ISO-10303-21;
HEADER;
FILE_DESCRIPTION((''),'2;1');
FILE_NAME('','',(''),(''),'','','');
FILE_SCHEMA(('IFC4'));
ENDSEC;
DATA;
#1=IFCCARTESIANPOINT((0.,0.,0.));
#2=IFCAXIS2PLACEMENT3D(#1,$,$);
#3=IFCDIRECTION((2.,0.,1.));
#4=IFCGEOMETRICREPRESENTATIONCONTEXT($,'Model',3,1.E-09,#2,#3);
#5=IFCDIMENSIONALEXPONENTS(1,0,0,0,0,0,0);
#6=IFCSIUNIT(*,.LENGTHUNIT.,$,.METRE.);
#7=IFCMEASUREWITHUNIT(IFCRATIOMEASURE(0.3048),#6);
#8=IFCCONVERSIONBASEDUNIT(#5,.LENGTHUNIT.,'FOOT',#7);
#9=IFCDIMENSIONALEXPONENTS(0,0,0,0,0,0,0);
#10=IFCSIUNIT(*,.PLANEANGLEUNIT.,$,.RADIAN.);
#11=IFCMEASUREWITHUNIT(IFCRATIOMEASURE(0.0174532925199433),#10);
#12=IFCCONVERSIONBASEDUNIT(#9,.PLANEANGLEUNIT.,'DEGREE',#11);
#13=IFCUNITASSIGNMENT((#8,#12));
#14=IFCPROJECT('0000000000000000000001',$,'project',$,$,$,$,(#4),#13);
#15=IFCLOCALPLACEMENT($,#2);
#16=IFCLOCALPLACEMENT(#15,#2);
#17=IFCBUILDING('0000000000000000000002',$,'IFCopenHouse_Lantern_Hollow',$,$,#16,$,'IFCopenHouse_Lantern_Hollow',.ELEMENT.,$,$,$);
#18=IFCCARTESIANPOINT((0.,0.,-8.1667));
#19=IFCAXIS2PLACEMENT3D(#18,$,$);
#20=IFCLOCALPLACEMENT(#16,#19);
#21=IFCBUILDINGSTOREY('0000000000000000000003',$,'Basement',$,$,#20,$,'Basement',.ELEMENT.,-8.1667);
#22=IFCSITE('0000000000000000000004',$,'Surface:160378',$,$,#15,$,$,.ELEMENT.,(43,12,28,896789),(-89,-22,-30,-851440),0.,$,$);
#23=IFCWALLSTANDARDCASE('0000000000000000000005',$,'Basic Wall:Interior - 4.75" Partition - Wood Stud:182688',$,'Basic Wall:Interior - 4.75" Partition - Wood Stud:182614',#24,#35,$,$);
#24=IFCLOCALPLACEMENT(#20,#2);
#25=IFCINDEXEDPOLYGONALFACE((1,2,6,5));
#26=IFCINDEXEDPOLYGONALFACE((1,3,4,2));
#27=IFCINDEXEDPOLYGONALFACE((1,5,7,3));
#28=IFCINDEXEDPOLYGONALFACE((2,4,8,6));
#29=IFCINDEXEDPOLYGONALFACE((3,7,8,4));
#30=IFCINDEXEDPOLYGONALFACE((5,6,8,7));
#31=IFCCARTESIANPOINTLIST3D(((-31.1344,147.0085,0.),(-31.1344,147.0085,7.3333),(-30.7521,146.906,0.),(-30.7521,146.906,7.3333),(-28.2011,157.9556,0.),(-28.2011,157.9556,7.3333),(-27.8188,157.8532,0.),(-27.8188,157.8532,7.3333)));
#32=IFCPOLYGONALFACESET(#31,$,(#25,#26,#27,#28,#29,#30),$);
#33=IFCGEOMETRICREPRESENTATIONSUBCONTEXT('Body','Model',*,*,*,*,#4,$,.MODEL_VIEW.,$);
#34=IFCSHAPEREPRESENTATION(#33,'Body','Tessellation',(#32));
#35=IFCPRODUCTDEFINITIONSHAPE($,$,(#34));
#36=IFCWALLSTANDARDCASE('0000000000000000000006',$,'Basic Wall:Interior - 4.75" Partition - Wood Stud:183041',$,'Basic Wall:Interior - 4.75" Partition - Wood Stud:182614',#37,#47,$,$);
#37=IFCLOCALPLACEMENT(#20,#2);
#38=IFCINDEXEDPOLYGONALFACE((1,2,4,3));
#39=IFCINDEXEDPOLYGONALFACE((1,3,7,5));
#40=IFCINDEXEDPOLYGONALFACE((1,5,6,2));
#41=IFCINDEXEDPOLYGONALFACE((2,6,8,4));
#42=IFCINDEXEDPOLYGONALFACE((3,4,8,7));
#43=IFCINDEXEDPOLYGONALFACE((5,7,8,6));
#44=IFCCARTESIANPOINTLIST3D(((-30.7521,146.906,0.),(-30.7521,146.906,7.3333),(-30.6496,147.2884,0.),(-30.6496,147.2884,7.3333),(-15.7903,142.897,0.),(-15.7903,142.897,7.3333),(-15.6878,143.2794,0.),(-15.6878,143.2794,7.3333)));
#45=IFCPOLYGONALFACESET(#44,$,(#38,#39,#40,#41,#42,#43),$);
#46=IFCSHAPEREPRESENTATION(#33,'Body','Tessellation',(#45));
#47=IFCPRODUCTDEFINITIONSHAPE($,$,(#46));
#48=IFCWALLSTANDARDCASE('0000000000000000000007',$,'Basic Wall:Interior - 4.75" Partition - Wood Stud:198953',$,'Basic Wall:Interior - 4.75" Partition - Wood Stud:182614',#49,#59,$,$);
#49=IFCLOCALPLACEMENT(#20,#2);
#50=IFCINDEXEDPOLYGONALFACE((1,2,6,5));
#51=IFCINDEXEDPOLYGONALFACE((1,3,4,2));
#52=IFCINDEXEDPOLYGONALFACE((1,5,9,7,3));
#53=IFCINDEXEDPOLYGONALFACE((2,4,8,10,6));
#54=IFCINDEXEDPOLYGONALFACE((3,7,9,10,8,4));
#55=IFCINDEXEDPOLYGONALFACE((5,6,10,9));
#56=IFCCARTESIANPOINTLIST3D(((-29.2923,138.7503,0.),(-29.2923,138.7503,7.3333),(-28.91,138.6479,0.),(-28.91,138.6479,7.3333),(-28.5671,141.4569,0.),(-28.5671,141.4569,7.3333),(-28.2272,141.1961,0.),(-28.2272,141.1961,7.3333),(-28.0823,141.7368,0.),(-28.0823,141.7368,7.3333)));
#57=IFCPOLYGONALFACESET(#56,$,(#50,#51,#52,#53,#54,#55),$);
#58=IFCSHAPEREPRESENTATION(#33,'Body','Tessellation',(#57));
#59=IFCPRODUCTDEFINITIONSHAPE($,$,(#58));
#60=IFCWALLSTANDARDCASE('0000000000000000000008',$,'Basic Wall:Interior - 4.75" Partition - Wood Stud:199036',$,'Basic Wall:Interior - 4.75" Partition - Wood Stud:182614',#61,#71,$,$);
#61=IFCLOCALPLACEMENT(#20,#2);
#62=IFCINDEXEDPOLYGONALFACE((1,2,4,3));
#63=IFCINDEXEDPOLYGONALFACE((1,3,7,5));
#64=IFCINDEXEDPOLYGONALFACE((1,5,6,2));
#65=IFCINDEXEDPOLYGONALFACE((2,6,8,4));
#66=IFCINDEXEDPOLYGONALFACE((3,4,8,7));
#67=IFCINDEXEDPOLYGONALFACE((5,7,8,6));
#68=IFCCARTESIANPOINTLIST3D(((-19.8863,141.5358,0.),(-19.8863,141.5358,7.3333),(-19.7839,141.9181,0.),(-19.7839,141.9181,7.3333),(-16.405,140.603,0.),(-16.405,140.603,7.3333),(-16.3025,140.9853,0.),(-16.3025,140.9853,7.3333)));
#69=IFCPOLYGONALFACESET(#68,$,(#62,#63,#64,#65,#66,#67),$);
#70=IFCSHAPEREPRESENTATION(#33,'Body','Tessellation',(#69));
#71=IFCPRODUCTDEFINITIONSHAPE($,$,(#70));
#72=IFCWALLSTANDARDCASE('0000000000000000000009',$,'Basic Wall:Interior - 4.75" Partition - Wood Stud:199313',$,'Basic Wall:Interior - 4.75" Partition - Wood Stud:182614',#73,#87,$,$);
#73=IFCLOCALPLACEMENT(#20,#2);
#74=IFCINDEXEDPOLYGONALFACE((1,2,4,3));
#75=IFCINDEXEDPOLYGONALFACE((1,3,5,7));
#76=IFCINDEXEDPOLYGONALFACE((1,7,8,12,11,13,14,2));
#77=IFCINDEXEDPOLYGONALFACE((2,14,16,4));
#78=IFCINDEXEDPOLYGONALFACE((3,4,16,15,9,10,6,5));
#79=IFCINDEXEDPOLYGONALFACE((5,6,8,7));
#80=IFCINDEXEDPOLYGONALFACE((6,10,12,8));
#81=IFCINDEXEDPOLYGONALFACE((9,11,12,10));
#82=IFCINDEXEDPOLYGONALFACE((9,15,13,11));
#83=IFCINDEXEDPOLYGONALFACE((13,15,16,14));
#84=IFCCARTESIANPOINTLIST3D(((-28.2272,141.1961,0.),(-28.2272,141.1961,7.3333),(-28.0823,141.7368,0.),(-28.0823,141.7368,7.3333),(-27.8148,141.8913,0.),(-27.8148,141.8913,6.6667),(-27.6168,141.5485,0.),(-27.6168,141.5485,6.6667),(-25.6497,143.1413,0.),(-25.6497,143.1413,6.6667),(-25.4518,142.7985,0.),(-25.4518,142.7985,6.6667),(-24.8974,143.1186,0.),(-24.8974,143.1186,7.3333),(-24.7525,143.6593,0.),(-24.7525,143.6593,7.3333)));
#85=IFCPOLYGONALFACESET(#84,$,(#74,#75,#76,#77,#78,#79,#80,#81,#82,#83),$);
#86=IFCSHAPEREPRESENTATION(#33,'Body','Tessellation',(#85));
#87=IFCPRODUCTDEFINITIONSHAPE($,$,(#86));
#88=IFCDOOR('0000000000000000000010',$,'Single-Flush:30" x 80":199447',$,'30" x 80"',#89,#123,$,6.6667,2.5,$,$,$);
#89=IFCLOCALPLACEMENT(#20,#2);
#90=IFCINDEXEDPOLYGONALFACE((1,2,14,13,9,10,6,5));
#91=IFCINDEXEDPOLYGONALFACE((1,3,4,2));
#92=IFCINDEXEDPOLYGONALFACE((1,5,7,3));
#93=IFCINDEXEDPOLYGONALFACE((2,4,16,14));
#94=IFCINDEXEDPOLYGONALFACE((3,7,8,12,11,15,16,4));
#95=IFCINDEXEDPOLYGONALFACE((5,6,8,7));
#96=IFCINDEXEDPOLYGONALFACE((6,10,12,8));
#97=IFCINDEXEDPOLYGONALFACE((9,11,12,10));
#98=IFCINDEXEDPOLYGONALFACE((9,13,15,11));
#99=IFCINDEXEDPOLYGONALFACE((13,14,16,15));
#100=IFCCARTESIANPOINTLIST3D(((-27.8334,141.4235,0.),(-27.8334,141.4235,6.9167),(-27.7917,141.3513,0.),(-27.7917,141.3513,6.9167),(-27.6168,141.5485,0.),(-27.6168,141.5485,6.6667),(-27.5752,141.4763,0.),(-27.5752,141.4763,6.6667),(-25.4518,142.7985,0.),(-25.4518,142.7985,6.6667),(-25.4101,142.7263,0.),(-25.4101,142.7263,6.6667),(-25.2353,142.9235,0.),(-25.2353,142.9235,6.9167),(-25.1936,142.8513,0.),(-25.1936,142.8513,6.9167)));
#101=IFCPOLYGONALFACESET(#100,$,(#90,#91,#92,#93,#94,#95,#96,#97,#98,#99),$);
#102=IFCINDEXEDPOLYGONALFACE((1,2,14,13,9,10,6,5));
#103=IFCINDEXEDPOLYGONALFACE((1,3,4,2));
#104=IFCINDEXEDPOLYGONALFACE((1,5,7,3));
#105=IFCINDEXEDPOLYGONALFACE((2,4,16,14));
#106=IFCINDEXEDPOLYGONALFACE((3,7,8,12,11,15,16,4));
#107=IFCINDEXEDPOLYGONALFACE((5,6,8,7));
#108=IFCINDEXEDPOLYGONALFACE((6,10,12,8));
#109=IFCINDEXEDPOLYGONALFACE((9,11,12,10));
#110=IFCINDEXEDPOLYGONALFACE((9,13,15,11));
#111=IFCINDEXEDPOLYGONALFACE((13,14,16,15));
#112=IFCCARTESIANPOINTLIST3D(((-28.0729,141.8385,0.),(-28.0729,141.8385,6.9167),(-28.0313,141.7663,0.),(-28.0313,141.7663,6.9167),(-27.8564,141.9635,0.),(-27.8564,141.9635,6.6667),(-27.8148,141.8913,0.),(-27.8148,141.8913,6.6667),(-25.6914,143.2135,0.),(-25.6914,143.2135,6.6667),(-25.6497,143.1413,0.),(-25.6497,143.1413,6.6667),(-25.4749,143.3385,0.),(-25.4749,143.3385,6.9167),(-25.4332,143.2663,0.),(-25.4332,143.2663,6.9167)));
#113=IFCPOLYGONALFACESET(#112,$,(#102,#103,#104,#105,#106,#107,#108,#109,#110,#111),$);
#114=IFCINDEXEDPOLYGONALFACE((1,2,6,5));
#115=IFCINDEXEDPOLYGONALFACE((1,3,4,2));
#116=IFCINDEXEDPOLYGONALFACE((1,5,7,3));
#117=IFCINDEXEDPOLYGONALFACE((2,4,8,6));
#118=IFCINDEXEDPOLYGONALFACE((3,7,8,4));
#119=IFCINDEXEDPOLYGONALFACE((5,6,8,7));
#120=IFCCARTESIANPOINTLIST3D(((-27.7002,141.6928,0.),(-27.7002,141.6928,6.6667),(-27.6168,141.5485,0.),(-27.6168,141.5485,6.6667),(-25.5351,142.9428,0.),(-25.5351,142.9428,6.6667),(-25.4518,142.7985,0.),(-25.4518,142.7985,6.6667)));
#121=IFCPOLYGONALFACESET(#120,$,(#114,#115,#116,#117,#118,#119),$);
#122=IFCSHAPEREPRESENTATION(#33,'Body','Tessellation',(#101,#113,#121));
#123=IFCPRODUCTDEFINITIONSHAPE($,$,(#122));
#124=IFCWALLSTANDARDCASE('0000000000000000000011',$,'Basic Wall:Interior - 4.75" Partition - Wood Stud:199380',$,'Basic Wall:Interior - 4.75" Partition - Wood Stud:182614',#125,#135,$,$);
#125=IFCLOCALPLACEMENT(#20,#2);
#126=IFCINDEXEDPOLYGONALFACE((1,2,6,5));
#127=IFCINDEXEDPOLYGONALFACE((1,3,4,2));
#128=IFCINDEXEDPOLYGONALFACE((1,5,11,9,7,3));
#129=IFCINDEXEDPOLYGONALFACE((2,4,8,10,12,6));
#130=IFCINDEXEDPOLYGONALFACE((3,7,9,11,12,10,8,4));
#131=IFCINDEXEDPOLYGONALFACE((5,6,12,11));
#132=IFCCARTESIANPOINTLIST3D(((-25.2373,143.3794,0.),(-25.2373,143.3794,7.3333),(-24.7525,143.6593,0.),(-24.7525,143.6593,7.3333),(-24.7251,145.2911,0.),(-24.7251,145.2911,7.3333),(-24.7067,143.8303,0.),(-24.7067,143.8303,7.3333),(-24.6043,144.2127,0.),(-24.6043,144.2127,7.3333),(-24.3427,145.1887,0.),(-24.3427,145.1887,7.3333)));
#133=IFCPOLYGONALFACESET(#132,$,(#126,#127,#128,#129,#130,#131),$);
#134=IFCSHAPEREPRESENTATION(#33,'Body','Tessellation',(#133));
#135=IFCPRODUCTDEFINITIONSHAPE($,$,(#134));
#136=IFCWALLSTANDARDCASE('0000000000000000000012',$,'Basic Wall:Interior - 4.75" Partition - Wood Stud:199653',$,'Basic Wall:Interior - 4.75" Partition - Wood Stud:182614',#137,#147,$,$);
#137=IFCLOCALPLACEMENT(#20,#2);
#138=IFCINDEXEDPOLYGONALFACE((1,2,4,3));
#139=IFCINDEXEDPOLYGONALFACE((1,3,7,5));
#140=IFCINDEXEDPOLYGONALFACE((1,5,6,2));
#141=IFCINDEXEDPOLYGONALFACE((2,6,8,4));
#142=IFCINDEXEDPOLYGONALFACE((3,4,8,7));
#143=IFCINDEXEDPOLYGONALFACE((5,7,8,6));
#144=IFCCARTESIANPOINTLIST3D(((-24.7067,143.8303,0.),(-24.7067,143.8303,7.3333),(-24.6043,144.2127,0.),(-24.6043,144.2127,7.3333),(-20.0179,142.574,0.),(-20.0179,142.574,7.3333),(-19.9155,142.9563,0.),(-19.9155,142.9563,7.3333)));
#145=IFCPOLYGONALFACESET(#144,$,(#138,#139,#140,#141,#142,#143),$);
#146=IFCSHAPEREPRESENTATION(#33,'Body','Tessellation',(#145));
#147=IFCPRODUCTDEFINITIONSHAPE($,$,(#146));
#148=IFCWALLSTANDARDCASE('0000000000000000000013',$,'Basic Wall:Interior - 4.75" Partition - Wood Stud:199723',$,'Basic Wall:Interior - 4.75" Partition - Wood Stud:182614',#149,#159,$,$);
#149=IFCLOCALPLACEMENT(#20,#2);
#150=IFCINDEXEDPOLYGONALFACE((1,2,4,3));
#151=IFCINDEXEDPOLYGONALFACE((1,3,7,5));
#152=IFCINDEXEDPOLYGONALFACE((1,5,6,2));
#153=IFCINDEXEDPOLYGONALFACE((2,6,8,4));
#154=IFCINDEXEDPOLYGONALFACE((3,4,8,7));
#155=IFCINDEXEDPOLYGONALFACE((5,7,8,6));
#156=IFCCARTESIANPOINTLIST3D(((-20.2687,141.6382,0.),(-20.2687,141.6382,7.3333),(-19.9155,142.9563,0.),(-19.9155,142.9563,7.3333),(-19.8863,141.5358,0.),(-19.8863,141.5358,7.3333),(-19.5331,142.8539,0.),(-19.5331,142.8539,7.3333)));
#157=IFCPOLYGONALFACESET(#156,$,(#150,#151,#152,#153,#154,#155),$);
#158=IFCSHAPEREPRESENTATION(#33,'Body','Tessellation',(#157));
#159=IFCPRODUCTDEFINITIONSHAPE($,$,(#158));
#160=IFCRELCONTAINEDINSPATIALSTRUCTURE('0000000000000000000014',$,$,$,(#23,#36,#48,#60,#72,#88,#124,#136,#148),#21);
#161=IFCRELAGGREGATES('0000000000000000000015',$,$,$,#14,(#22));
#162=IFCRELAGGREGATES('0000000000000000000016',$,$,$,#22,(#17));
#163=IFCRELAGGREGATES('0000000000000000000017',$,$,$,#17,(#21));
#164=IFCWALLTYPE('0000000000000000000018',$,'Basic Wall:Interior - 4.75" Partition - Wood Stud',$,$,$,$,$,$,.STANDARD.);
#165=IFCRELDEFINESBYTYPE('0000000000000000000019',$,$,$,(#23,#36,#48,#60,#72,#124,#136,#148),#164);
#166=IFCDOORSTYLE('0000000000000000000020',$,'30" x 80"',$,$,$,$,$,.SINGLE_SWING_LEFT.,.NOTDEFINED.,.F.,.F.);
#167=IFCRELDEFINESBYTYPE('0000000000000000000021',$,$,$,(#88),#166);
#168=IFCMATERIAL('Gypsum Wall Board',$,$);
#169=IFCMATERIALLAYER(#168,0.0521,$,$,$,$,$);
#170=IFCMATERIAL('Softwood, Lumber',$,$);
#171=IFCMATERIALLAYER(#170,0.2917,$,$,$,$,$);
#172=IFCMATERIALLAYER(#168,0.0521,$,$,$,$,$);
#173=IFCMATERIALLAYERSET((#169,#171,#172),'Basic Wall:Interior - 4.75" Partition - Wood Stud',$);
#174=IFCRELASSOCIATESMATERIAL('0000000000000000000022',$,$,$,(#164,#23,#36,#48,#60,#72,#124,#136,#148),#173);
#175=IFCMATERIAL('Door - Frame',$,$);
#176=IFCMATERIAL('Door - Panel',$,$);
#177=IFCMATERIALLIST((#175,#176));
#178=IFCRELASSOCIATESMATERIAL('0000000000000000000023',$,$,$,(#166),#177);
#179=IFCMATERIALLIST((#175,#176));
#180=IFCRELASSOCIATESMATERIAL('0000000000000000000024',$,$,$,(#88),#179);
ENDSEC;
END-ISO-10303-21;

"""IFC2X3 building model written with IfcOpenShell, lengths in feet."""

from ifc_helpers import new_model, entity, si_unit, converted_unit, direction, frame, frame_2d, origin, origin_2d_with_axis, place, context, subcontext, project, spatial, polyline, rectangle, outline, extrude, source, transform, mapped, material, material_list, layer, layer_set, layer_usage, type_object, type_shapes, element, fill, save


model = new_model("IFC2X3")

# Units and contexts
model_context = context("Model", 3, precision=1e-09, world=origin(), true_north=direction((2.0, 0.0, 1.0)))
body_context = subcontext(model_context, "Body", "Model", "MODEL_VIEW")
ifc_project = project(units=[converted_unit("LENGTHUNIT", "FOOT", entity("IfcRatioMeasure", 0.3048), si_unit("LENGTHUNIT", "METRE"), dimensions=[1, 0, 0, 0, 0, 0, 0]), converted_unit("PLANEANGLEUNIT", "DEGREE", entity("IfcRatioMeasure", 0.0174532925199433), si_unit("PLANEANGLEUNIT", "RADIAN"), dimensions=[0, 0, 0, 0, 0, 0, 0])], contexts=[model_context])

# Site, building, storey
site_placement = place(None, origin())
site = spatial("IfcSite", under=ifc_project, at=site_placement, Name="Surface:160378", CompositionType="ELEMENT", RefLatitude=(43, 12, 28, 896789), RefLongitude=(-89, -22, -30, -851440), RefElevation=0.0)
building_placement = place(site_placement, origin())
building = spatial("IfcBuilding", under=site, at=building_placement, Name="IFCopenHouse_Lantern_Hollow", LongName="IFCopenHouse_Lantern_Hollow", CompositionType="ELEMENT")
storey_placement = place(building_placement, frame((0.0, 0.0, -8.1667)))
storey = spatial("IfcBuildingStorey", under=building, at=storey_placement, Name="Basement", LongName="Basement", CompositionType="ELEMENT", Elevation=-8.1667)

# Shared definitions
ifc_material_1 = material(Name="Softwood, Lumber")

# Walls
ifc_material_2 = material(Name="Gypsum Wall Board")
ifc_layer_1 = layer(ifc_material_2, 0.0521)
ifc_layer_2 = layer(ifc_material_1, 0.2917)
ifc_layer_3 = layer(ifc_material_2, 0.0521)
ifc_layer_set_1 = layer_set([ifc_layer_1, ifc_layer_2, ifc_layer_3], Name="Basic Wall:Interior - 4.75\" Partition - Wood Stud")
ifc_layer_usage_1 = layer_usage(ifc_layer_set_1, "AXIS2", "NEGATIVE", 0.1979)
wall_type_1 = type_object("IfcWallType", Name="Basic Wall:Interior - 4.75\" Partition - Wood Stud", PredefinedType="STANDARD", material=ifc_layer_set_1)
wall_1_placement = place(storey_placement, frame((-28.0099, 157.9044, 0.0), z_axis=(0.0, 0.0, 1.0), x_axis=(-0.258819, -0.965926, 0.0)))
element("IfcWallStandardCase", 1, at=wall_1_placement, inside=storey, type_object=wall_type_1, material=ifc_layer_usage_1, Name="Basic Wall:Interior - 4.75\" Partition - Wood Stud:182688", ObjectType="Basic Wall:Interior - 4.75\" Partition - Wood Stud:182614", context=body_context, shape_type="SweptSolid", body=[
    extrude(rectangle(XDim=11.3333, YDim=0.3958, at=frame_2d((5.6667, 0.0), x_axis=(-1.0, 0.0))), origin(), (0.0, 0.0, 1.0), 7.3333),
])
ifc_layer_usage_2 = layer_usage(ifc_layer_set_1, "AXIS2", "NEGATIVE", 0.1979)
wall_2_placement = place(storey_placement, frame((-30.7008, 147.0972, 0.0), z_axis=(0.0, 0.0, 1.0), x_axis=(0.965926, -0.258819, 0.0)))
element("IfcWallStandardCase", 2, at=wall_2_placement, inside=storey, type_object=wall_type_1, material=ifc_layer_usage_2, Name="Basic Wall:Interior - 4.75\" Partition - Wood Stud:183041", ObjectType="Basic Wall:Interior - 4.75\" Partition - Wood Stud:182614", context=body_context, shape_type="SweptSolid", body=[
    extrude(rectangle(XDim=15.4896, YDim=0.3958, at=frame_2d((7.7448, 0.0), x_axis=(-1.0, 0.0))), origin(), (0.0, 0.0, 1.0), 7.3333),
])
ifc_layer_usage_3 = layer_usage(ifc_layer_set_1, "AXIS2", "NEGATIVE", 0.1979)
wall_3_placement = place(storey_placement, frame((-28.2735, 141.7881, 0.0), z_axis=(0.0, 0.0, 1.0), x_axis=(-0.258819, -0.965926, 0.0)))
element("IfcWallStandardCase", 3, at=wall_3_placement, inside=storey, type_object=wall_type_1, material=ifc_layer_usage_3, Name="Basic Wall:Interior - 4.75\" Partition - Wood Stud:198953", ObjectType="Basic Wall:Interior - 4.75\" Partition - Wood Stud:182614", context=body_context, shape_type="SweptSolid", body=[
    extrude(outline(polyline([(3.1979, -0.1979), (3.1979, 0.1979), (0.5598, 0.1979), (0.0, 0.1979), (0.3958, -0.1979), (3.1979, -0.1979)])), origin(), (0.0, 0.0, 1.0), 7.3333),
])
ifc_layer_usage_4 = layer_usage(ifc_layer_set_1, "AXIS2", "NEGATIVE", 0.1979)
wall_4_placement = place(storey_placement, frame((-19.8351, 141.727, 0.0), z_axis=(0.0, 0.0, 1.0), x_axis=(0.965926, -0.258819, 0.0)))
element("IfcWallStandardCase", 4, at=wall_4_placement, inside=storey, type_object=wall_type_1, material=ifc_layer_usage_4, Name="Basic Wall:Interior - 4.75\" Partition - Wood Stud:199036", ObjectType="Basic Wall:Interior - 4.75\" Partition - Wood Stud:182614", context=body_context, shape_type="SweptSolid", body=[
    extrude(rectangle(XDim=3.6042, YDim=0.3958, at=frame_2d((1.8021, 0.0), x_axis=(-1.0, 0.0))), origin(), (0.0, 0.0, 1.0), 7.3333),
])

# Wall, opening, door
ifc_layer_usage_5 = layer_usage(ifc_layer_set_1, "AXIS2", "NEGATIVE", 0.1979)
wall_5_placement = place(storey_placement, frame((-28.3262, 141.3675, 0.0), z_axis=(0.0, 0.0, 1.0), x_axis=(0.866025, 0.5, 0.0)))
wall_5 = element("IfcWallStandardCase", 5, at=wall_5_placement, inside=storey, type_object=wall_type_1, material=ifc_layer_usage_5, Name="Basic Wall:Interior - 4.75\" Partition - Wood Stud:199313", ObjectType="Basic Wall:Interior - 4.75\" Partition - Wood Stud:182614", context=body_context, shape_type="SweptSolid", body=[
    extrude(outline(polyline([(0.0, -0.1979), (3.8449, -0.1979), (4.2407, 0.1979), (3.6809, 0.1979), (0.3958, 0.1979), (0.0, -0.1979)])), origin(), (0.0, 0.0, 1.0), 7.3333),
])
opening_placement = place(wall_5_placement, frame((3.2048, 0.1979, 0.0)))
opening = element("IfcOpeningElement", 6, at=opening_placement, cuts=wall_5, ObjectType="Opening", context=body_context, shape_type="SweptSolid", body=[
    extrude(rectangle(XDim=2.5, YDim=6.6667, at=frame_2d((3.3333, 1.25), x_axis=(0.0, -1.0))), frame((0.0, 0.0, 0.0), z_axis=(0.0, -1.0, 0.0), x_axis=(0.0, 0.0, 1.0)), (0.0, 0.0, 1.0), 0.3958),
])
ifc_material_3 = material(Name="Door - Frame")
ifc_material_4 = material(Name="Door - Panel")
ifc_material_list_1 = material_list([ifc_material_3, ifc_material_4])
ifc_material_list_2 = material_list([ifc_material_3, ifc_material_4])
door_style = type_object("IfcDoorStyle", Name="30\" x 80\"", ConstructionType="NOTDEFINED", OperationType="SINGLE_SWING_LEFT", ParameterTakesPrecedence=False, Sizeable=False, material=ifc_material_list_2)
shared_shape_1 = source(origin(), body_context, "Body", "SweptSolid", [
    extrude(outline(polyline([(-1.5, -3.5208), (1.5, -3.5208), (1.5, 3.3958), (1.25, 3.3958), (1.25, -3.2708), (-1.25, -3.2708), (-1.25, 3.3958), (-1.5, 3.3958), (-1.5, -3.5208)])), frame((1.25, 0.4792, 3.3958), z_axis=(0.0, -1.0, 0.0), x_axis=(-1.0, 0.0, 0.0)), (0.0, 0.0, 1.0), 0.0833),
    extrude(outline(polyline([(-3.5208, -1.5), (3.3958, -1.5), (3.3958, -1.25), (-3.2708, -1.25), (-3.2708, 1.25), (3.3958, 1.25), (3.3958, 1.5), (-3.5208, 1.5), (-3.5208, -1.5)])), frame((1.25, 0.0, 3.3958), z_axis=(0.0, -1.0, 0.0), x_axis=(0.0, 0.0, -1.0)), (0.0, 0.0, 1.0), 0.0833),
    extrude(rectangle(XDim=2.5, YDim=0.1667, at=origin_2d_with_axis()), frame((1.25, 0.3125, 0.0)), (0.0, 0.0, 1.0), 6.6667),
])
type_shapes(door_style, [shared_shape_1])
door_placement = place(opening_placement, frame((0.0, 0.0, 0.0), z_axis=(0.0, 0.0, 1.0), x_axis=(-1.0, 0.0, 0.0)))
door = element("IfcDoor", 7, at=door_placement, inside=storey, type_object=door_style, material=ifc_material_list_1, Name="Single-Flush:30\" x 80\":199447", ObjectType="30\" x 80\"", OverallHeight=6.6667, OverallWidth=2.5, context=body_context, shape_type="MappedRepresentation", body=[
    mapped(shared_shape_1, transform((0.0, 0.0, 0.0), scale=1.0)),
])
fill(opening, door)

# Walls
ifc_layer_usage_6 = layer_usage(ifc_layer_set_1, "AXIS2", "NEGATIVE", 0.1979)
wall_6_placement = place(storey_placement, frame((-25.0462, 143.3282, 0.0), z_axis=(0.0, 0.0, 1.0), x_axis=(0.258819, 0.965926, 0.0)))
element("IfcWallStandardCase", 8, at=wall_6_placement, inside=storey, type_object=wall_type_1, material=ifc_layer_usage_6, Name="Basic Wall:Interior - 4.75\" Partition - Wood Stud:199380", ObjectType="Basic Wall:Interior - 4.75\" Partition - Wood Stud:182614", context=body_context, shape_type="SweptSolid", body=[
    extrude(outline(polyline([(1.9792, -0.1979), (1.9792, 0.1979), (0.0, 0.1979), (0.3958, -0.1979), (0.5729, -0.1979), (0.9688, -0.1979), (1.9792, -0.1979)])), origin(), (0.0, 0.0, 1.0), 7.3333),
])
ifc_layer_usage_7 = layer_usage(ifc_layer_set_1, "AXIS2", "NEGATIVE", 0.1979)
wall_7_placement = place(storey_placement, frame((-24.6555, 144.0215, 0.0), z_axis=(0.0, 0.0, 1.0), x_axis=(0.965926, -0.258819, 0.0)))
element("IfcWallStandardCase", 9, at=wall_7_placement, inside=storey, type_object=wall_type_1, material=ifc_layer_usage_7, Name="Basic Wall:Interior - 4.75\" Partition - Wood Stud:199653", ObjectType="Basic Wall:Interior - 4.75\" Partition - Wood Stud:182614", context=body_context, shape_type="SweptSolid", body=[
    extrude(rectangle(XDim=4.8542, YDim=0.3958, at=frame_2d((2.4271, 0.0), x_axis=(-1.0, 0.0))), origin(), (0.0, 0.0, 1.0), 7.3333),
])
ifc_layer_usage_8 = layer_usage(ifc_layer_set_1, "AXIS2", "NEGATIVE", 0.1979)
wall_8_placement = place(storey_placement, frame((-20.0775, 141.587, 0.0), z_axis=(0.0, 0.0, 1.0), x_axis=(0.258819, 0.965926, 0.0)))
element("IfcWallStandardCase", 10, at=wall_8_placement, inside=storey, type_object=wall_type_1, material=ifc_layer_usage_8, Name="Basic Wall:Interior - 4.75\" Partition - Wood Stud:199723", ObjectType="Basic Wall:Interior - 4.75\" Partition - Wood Stud:182614", context=body_context, shape_type="SweptSolid", body=[
    extrude(rectangle(XDim=1.3646, YDim=0.3958, at=frame_2d((0.6823, 0.0), x_axis=(-1.0, 0.0))), origin(), (0.0, 0.0, 1.0), 7.3333),
])

save(model, "model.ifc")
